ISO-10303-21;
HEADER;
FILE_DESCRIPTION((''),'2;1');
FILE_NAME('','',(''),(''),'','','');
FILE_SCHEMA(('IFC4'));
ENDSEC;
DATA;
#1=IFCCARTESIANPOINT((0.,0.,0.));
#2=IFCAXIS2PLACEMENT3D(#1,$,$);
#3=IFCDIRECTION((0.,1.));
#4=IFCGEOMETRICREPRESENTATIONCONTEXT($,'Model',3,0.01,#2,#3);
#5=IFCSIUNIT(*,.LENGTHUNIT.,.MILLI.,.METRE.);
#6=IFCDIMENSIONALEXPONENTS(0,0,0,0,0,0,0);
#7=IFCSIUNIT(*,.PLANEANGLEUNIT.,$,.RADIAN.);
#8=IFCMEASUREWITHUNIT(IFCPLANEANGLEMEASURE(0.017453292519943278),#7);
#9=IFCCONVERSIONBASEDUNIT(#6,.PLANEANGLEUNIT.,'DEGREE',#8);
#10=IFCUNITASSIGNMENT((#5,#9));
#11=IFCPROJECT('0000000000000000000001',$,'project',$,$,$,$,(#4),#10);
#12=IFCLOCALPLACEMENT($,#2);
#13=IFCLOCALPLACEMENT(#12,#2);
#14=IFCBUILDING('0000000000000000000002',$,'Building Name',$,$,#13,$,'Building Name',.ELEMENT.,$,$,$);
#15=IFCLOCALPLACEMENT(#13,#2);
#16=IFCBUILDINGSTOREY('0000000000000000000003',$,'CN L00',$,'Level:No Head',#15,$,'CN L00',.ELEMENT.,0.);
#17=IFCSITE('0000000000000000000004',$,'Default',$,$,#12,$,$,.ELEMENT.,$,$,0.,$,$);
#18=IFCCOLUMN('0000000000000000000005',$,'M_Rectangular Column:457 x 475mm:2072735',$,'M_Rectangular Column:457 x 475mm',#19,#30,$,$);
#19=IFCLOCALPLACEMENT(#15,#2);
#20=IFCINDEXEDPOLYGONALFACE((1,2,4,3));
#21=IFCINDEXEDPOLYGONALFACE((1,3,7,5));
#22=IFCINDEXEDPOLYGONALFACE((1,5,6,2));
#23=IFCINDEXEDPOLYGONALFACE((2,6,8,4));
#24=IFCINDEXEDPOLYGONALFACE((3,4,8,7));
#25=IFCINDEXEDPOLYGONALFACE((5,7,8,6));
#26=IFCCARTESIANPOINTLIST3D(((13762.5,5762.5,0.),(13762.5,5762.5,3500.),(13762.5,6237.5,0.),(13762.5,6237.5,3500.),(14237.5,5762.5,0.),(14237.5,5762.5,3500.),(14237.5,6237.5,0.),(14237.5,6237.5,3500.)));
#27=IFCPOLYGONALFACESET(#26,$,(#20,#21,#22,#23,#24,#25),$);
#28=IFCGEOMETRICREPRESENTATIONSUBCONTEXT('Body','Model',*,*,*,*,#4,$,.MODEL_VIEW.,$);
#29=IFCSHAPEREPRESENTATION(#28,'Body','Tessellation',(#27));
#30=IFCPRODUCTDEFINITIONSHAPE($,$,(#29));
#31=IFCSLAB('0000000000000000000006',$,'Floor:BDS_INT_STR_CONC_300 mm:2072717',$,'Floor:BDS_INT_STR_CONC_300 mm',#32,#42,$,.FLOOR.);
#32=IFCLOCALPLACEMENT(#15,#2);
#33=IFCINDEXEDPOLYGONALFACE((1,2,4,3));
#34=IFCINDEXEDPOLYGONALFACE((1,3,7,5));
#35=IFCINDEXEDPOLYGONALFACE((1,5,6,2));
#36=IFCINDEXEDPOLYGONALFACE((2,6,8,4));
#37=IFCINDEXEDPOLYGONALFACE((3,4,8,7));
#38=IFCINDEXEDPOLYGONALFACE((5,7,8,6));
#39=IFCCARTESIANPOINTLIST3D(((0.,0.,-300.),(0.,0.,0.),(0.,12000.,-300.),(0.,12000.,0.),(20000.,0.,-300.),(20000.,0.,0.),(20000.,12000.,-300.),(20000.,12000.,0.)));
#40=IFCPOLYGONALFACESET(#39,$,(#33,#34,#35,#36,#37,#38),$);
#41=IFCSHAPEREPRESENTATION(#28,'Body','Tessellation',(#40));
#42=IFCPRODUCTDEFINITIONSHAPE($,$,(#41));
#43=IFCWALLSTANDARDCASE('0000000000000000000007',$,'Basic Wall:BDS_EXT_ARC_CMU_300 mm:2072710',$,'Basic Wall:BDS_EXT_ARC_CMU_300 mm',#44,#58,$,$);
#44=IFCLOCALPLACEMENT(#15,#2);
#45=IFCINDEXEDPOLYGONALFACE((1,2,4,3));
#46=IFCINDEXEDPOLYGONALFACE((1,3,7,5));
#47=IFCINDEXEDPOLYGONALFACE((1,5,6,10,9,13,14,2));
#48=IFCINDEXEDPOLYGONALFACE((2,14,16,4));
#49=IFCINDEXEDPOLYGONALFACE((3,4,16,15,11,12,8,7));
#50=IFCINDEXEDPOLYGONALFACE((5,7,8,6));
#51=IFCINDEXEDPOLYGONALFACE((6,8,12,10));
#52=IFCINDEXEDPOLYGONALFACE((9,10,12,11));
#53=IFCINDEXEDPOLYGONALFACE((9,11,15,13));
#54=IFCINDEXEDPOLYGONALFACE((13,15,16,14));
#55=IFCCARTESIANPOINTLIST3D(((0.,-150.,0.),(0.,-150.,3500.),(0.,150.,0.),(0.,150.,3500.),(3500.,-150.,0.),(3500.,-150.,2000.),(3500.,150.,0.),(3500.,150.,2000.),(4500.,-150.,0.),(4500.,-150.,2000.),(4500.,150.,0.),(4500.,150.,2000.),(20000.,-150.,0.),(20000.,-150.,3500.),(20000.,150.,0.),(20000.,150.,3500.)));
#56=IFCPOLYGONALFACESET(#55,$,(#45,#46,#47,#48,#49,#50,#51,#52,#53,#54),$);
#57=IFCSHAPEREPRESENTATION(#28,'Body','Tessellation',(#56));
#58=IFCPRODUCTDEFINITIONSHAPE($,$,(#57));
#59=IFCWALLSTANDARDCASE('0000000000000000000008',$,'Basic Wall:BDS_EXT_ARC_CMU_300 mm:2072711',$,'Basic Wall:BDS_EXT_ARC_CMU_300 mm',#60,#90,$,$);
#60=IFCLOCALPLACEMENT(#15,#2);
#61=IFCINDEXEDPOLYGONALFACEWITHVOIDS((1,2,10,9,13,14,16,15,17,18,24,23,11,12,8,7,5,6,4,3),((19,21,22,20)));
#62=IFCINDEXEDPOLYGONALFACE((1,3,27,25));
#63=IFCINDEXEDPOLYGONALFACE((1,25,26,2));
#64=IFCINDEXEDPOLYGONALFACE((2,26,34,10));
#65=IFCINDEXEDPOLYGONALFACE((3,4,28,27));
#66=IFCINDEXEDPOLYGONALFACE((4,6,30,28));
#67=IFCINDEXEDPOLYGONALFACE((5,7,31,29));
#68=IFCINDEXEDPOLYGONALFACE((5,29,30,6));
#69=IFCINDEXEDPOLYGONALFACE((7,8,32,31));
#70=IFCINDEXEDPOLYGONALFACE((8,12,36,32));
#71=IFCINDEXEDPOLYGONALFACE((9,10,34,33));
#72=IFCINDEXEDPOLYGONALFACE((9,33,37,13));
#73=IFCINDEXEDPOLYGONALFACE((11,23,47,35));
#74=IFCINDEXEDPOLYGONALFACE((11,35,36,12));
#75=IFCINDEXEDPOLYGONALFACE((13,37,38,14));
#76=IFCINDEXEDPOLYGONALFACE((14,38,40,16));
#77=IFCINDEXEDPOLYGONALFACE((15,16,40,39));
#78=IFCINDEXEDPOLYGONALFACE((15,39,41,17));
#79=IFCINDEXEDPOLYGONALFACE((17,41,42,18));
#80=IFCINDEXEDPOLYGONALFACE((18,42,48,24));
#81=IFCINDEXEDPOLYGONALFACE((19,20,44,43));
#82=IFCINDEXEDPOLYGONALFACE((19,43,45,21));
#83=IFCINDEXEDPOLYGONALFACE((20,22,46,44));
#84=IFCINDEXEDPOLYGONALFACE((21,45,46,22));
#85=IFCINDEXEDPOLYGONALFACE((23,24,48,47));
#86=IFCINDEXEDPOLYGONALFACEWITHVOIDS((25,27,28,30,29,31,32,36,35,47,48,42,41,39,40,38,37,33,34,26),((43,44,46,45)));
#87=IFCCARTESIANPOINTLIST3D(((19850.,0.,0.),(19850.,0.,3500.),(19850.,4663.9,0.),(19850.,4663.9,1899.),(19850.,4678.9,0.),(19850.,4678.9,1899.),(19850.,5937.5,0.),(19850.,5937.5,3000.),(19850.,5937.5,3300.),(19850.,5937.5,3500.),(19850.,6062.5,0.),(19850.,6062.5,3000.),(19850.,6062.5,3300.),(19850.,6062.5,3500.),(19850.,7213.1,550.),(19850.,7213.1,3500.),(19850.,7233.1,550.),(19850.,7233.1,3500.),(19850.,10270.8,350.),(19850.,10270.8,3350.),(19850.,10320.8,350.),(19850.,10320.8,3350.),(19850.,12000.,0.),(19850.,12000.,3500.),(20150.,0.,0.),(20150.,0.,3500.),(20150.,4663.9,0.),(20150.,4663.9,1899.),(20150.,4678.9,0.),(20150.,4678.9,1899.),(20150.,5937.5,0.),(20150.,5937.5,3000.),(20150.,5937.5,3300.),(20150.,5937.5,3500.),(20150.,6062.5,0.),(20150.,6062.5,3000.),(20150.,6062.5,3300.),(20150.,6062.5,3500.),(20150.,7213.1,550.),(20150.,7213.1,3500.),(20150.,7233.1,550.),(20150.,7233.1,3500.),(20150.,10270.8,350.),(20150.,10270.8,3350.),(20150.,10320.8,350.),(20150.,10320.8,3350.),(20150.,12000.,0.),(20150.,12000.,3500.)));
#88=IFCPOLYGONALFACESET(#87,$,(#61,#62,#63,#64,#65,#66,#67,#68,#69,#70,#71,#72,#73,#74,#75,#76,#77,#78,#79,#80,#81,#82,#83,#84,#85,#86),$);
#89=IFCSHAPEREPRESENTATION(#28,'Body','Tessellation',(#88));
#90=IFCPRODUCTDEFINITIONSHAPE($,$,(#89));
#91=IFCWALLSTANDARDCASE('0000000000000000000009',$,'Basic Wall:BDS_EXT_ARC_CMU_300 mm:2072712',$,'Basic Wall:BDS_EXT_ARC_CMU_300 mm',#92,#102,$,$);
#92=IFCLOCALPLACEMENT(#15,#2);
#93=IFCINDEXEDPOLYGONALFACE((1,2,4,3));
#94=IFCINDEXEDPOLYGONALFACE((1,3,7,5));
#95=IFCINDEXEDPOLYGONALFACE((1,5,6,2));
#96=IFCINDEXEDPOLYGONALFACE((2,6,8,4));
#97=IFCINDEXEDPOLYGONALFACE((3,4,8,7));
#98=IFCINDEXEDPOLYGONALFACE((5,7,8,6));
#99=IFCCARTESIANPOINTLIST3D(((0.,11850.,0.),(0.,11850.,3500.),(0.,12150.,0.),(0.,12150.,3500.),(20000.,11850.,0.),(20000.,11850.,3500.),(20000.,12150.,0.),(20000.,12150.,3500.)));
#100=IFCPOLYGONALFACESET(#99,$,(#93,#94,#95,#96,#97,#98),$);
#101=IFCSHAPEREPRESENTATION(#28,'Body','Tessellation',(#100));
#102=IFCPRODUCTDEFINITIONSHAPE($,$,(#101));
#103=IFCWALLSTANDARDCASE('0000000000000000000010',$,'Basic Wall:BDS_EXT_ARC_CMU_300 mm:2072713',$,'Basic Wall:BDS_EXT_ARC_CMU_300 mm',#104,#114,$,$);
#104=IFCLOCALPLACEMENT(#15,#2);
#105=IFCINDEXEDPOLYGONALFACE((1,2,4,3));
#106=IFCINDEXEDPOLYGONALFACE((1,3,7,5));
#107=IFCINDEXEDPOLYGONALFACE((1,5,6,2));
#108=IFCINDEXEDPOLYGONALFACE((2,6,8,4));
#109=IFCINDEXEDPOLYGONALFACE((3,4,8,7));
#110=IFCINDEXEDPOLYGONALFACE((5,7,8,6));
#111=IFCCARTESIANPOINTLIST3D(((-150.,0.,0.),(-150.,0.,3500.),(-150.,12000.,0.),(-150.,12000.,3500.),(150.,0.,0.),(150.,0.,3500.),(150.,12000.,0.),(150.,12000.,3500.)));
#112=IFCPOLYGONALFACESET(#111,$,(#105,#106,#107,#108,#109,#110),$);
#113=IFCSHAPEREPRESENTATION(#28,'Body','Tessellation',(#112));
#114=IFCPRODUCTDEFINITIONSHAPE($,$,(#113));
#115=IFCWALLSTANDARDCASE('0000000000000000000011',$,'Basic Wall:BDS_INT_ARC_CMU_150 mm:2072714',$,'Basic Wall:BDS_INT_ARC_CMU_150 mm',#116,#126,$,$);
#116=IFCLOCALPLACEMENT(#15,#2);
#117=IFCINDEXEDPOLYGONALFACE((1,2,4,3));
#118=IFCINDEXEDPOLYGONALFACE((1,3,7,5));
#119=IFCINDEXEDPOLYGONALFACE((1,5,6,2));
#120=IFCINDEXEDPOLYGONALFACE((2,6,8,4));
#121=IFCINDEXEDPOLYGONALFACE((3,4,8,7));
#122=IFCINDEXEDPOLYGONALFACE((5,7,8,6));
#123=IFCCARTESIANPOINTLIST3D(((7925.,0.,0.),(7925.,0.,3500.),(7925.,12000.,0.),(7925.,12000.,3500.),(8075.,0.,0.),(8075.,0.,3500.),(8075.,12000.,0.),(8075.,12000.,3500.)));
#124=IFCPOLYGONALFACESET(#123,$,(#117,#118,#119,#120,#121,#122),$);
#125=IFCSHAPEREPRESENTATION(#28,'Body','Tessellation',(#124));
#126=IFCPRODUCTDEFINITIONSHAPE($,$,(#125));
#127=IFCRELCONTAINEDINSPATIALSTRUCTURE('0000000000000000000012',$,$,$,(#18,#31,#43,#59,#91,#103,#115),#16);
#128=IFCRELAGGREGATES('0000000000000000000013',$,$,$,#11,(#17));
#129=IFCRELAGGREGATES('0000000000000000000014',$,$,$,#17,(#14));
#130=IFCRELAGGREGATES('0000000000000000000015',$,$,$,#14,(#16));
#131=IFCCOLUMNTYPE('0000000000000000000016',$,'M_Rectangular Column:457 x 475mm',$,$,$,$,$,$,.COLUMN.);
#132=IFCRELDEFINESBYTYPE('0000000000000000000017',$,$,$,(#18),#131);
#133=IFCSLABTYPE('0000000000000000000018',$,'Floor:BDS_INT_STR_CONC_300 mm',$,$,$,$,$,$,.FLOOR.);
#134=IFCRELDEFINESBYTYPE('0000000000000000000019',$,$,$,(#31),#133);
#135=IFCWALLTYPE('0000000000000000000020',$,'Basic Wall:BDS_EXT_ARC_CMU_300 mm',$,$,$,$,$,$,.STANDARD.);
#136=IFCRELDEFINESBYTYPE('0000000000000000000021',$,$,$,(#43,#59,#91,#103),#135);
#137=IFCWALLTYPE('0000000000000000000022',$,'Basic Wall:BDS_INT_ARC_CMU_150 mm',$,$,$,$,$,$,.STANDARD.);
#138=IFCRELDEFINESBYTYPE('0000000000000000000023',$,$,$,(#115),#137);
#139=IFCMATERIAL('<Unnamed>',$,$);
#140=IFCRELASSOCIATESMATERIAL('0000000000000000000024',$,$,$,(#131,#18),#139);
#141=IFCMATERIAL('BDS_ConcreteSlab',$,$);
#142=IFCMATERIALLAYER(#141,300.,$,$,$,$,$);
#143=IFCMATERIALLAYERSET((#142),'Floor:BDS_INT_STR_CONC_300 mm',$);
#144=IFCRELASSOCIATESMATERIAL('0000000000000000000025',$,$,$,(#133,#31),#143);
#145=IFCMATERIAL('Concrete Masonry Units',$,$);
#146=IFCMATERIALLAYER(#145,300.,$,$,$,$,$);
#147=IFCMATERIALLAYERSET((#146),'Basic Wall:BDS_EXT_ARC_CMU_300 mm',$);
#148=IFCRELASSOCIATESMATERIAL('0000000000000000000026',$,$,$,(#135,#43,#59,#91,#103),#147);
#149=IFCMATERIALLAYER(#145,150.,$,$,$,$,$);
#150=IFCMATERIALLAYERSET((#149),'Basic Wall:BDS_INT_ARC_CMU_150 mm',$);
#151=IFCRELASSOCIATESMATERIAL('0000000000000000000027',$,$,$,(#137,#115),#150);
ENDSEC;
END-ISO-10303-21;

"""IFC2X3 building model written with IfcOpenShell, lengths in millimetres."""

from ifc_helpers import new_model, entity, si_unit, converted_unit, direction, frame, frame_2d, origin, origin_2d_with_axis, place, context, subcontext, project, spatial, polyline, rectangle, extrude, clip, bounded_halfspace, source, transform, mapped, material, layer, layer_set, layer_usage, type_object, type_shapes, element, save


model = new_model("IFC2X3")

# Units and contexts
model_context = context("Model", 3, precision=0.01, world=origin(), true_north=direction((0.0, 1.0)))
body_context = subcontext(model_context, "Body", "Model", "MODEL_VIEW")
ifc_project = project(units=[si_unit("LENGTHUNIT", "METRE", prefix="MILLI"), converted_unit("PLANEANGLEUNIT", "DEGREE", entity("IfcPlaneAngleMeasure", 0.017453292519943278), si_unit("PLANEANGLEUNIT", "RADIAN"), dimensions=[0, 0, 0, 0, 0, 0, 0])], contexts=[model_context])

# Site, building, storey
site_placement = place(None, origin())
site = spatial("IfcSite", under=ifc_project, at=site_placement, Name="Default", CompositionType="ELEMENT", RefElevation=0.0)
building_placement = place(site_placement, origin())
building = spatial("IfcBuilding", under=site, at=building_placement, Name="Building Name", LongName="Building Name", CompositionType="ELEMENT")
storey_placement = place(building_placement, origin())
storey = spatial("IfcBuildingStorey", under=building, at=storey_placement, Name="CN L00", ObjectType="Level:No Head", LongName="CN L00", CompositionType="ELEMENT", Elevation=0.0)

# Column
ifc_material_1 = material(Name="<Unnamed>")
column_type = type_object("IfcColumnType", Name="M_Rectangular Column:457 x 475mm", PredefinedType="COLUMN", material=ifc_material_1)
shared_shape = source(origin(), body_context, "Body", "SweptSolid", [
    extrude(rectangle(XDim=475.0, YDim=475.0, at=origin_2d_with_axis()), frame((0.0, 0.0, 0.0), z_axis=(0.0, 0.0, 1.0), x_axis=(-1.0, 0.0, 0.0)), (0.0, 0.0, 1.0), 3500.0),
])
type_shapes(column_type, [shared_shape])
column_placement = place(storey_placement, frame((14000.0, 6000.0, 0.0)))
element("IfcColumn", 1, at=column_placement, inside=storey, type_object=column_type, material=ifc_material_1, Name="M_Rectangular Column:457 x 475mm:2072735", ObjectType="M_Rectangular Column:457 x 475mm", context=body_context, shape_type="MappedRepresentation", body=[
    mapped(shared_shape, transform((0.0, 0.0, 0.0), scale=1.0)),
])

# Slab
ifc_material_2 = material(Name="BDS_ConcreteSlab")
ifc_layer_1 = layer(ifc_material_2, 300.0)
ifc_layer_set_1 = layer_set([ifc_layer_1], Name="Floor:BDS_INT_STR_CONC_300 mm")
ifc_layer_usage_1 = layer_usage(ifc_layer_set_1, "AXIS3", "POSITIVE", 0.0)
slab_type = type_object("IfcSlabType", Name="Floor:BDS_INT_STR_CONC_300 mm", PredefinedType="FLOOR", material=ifc_layer_set_1)
slab_placement = place(storey_placement, origin())
element("IfcSlab", 2, at=slab_placement, inside=storey, type_object=slab_type, material=ifc_layer_usage_1, Name="Floor:BDS_INT_STR_CONC_300 mm:2072717", ObjectType="Floor:BDS_INT_STR_CONC_300 mm", PredefinedType="FLOOR", context=body_context, shape_type="SweptSolid", body=[
    extrude(rectangle(XDim=12000.0, YDim=20000.0, at=origin_2d_with_axis()), frame((10000.0, 6000.0, 0.0), z_axis=(0.0, 0.0, -1.0), x_axis=(0.0, 1.0, 0.0)), (0.0, 0.0, 1.0), 300.0),
])

# Walls, openings
ifc_material_3 = material(Name="Concrete Masonry Units")
ifc_layer_2 = layer(ifc_material_3, 300.0)
ifc_layer_set_2 = layer_set([ifc_layer_2], Name="Basic Wall:BDS_EXT_ARC_CMU_300 mm")
ifc_layer_usage_2 = layer_usage(ifc_layer_set_2, "AXIS2", "NEGATIVE", 150.0)
wall_type_1 = type_object("IfcWallType", Name="Basic Wall:BDS_EXT_ARC_CMU_300 mm", PredefinedType="STANDARD", material=ifc_layer_set_2)
wall_1_placement = place(storey_placement, origin())
wall_1 = element("IfcWallStandardCase", 3, at=wall_1_placement, inside=storey, type_object=wall_type_1, material=ifc_layer_usage_2, Name="Basic Wall:BDS_EXT_ARC_CMU_300 mm:2072710", ObjectType="Basic Wall:BDS_EXT_ARC_CMU_300 mm", context=body_context, shape_type="SweptSolid", body=[
    extrude(rectangle(XDim=20000.0, YDim=300.0, at=frame_2d((10000.0, 0.0), x_axis=(1.0, 0.0))), origin(), (0.0, 0.0, 1.0), 3500.0),
])
opening_1_placement = place(wall_1_placement, frame((3500.0, -150.0, 0.0)))
element("IfcOpeningElement", 4, at=opening_1_placement, cuts=wall_1, ObjectType="Opening", context=body_context, shape_type="SweptSolid", body=[
    extrude(rectangle(XDim=1000.0, YDim=2000.0, at=frame_2d((1000.0, 500.0), x_axis=(0.0, 1.0))), frame((0.0, 0.0, 0.0), z_axis=(0.0, 1.0, 0.0), x_axis=(0.0, 0.0, 1.0)), (0.0, 0.0, 1.0), 300.0),
])
ifc_layer_usage_3 = layer_usage(ifc_layer_set_2, "AXIS2", "NEGATIVE", 150.0)
wall_2_placement = place(storey_placement, frame((20000.0, 0.0, 0.0), z_axis=(0.0, 0.0, 1.0), x_axis=(0.0, 1.0, 0.0)))
wall_2 = element("IfcWallStandardCase", 5, at=wall_2_placement, inside=storey, type_object=wall_type_1, material=ifc_layer_usage_3, Name="Basic Wall:BDS_EXT_ARC_CMU_300 mm:2072711", ObjectType="Basic Wall:BDS_EXT_ARC_CMU_300 mm", context=body_context, shape_type="Clipping", body=[
    clip(clip(clip(clip(extrude(rectangle(XDim=12000.0, YDim=300.0, at=frame_2d((6000.0, 0.0), x_axis=(-1.0, 0.0))), origin(), (0.0, 0.0, 1.0), 3500.0), bounded_halfspace(frame((7213.1, 150.0, 550.0), z_axis=(0.0, 0.0, -1.0), x_axis=(1.0, 0.0, 0.0)), True, frame((7213.1, 150.0, 550.0), z_axis=(0.0, 0.0, -1.0), x_axis=(1.0, 0.0, 0.0)), polyline([(0.0, 0.0), (20.0, 0.0), (20.0, 300.0), (0.0, 300.0), (0.0, 0.0)]))), bounded_halfspace(frame((4663.9, -150.0, 1899.0)), True, frame((4663.9, -150.0, 1899.0)), polyline([(0.0, 0.0), (15.0, 0.0), (15.0, 300.0), (0.0, 300.0), (0.0, 0.0)]))), bounded_halfspace(frame((5937.5, -150.0, 3000.0)), True, frame((5937.5, -150.0, 3000.0)), polyline([(0.0, 0.0), (125.0, 0.0), (125.0, 300.0), (0.0, 300.0), (0.0, 0.0)]))), bounded_halfspace(frame((5937.5, 150.0, 3300.0), z_axis=(0.0, 0.0, -1.0), x_axis=(1.0, 0.0, 0.0)), True, frame((5937.5, 150.0, 3300.0), z_axis=(0.0, 0.0, -1.0), x_axis=(1.0, 0.0, 0.0)), polyline([(0.0, 0.0), (125.0, 0.0), (125.0, 300.0), (0.0, 300.0), (0.0, 0.0)]))),
])
opening_2_placement = place(storey_placement, frame((20000.0, 0.0, 0.0), z_axis=(0.0, 0.0, 1.0), x_axis=(0.0, 1.0, 0.0)))
element("IfcOpeningElement", 6, at=opening_2_placement, cuts=wall_2, ObjectType="Opening", context=body_context, shape_type="SweptSolid", body=[
    extrude(rectangle(XDim=300.0, YDim=50.0, at=origin_2d_with_axis()), frame((10295.8, 0.0, 350.0), z_axis=(0.0, 0.0, 1.0), x_axis=(0.0, 1.0, 0.0)), (0.0, 0.0, 1.0), 3000.0),
])

# Walls
ifc_layer_usage_4 = layer_usage(ifc_layer_set_2, "AXIS2", "NEGATIVE", 150.0)
wall_3_placement = place(storey_placement, frame((20000.0, 12000.0, 0.0), z_axis=(0.0, 0.0, 1.0), x_axis=(-1.0, 0.0, 0.0)))
element("IfcWallStandardCase", 7, at=wall_3_placement, inside=storey, type_object=wall_type_1, material=ifc_layer_usage_4, Name="Basic Wall:BDS_EXT_ARC_CMU_300 mm:2072712", ObjectType="Basic Wall:BDS_EXT_ARC_CMU_300 mm", context=body_context, shape_type="SweptSolid", body=[
    extrude(rectangle(XDim=20000.0, YDim=300.0, at=frame_2d((10000.0, 0.0), x_axis=(-1.0, 0.0))), origin(), (0.0, 0.0, 1.0), 3500.0),
])
ifc_layer_usage_5 = layer_usage(ifc_layer_set_2, "AXIS2", "NEGATIVE", 150.0)
wall_4_placement = place(storey_placement, frame((0.0, 12000.0, 0.0), z_axis=(0.0, 0.0, 1.0), x_axis=(0.0, -1.0, 0.0)))
element("IfcWallStandardCase", 8, at=wall_4_placement, inside=storey, type_object=wall_type_1, material=ifc_layer_usage_5, Name="Basic Wall:BDS_EXT_ARC_CMU_300 mm:2072713", ObjectType="Basic Wall:BDS_EXT_ARC_CMU_300 mm", context=body_context, shape_type="SweptSolid", body=[
    extrude(rectangle(XDim=12000.0, YDim=300.0, at=frame_2d((6000.0, 0.0), x_axis=(-1.0, 0.0))), origin(), (0.0, 0.0, 1.0), 3500.0),
])
ifc_layer_3 = layer(ifc_material_3, 150.0)
ifc_layer_set_3 = layer_set([ifc_layer_3], Name="Basic Wall:BDS_INT_ARC_CMU_150 mm")
ifc_layer_usage_6 = layer_usage(ifc_layer_set_3, "AXIS2", "NEGATIVE", 75.0)
wall_type_2 = type_object("IfcWallType", Name="Basic Wall:BDS_INT_ARC_CMU_150 mm", PredefinedType="STANDARD", material=ifc_layer_set_3)
wall_5_placement = place(storey_placement, frame((8000.0, 0.0, 0.0), z_axis=(0.0, 0.0, 1.0), x_axis=(0.0, 1.0, 0.0)))
element("IfcWallStandardCase", 9, at=wall_5_placement, inside=storey, type_object=wall_type_2, material=ifc_layer_usage_6, Name="Basic Wall:BDS_INT_ARC_CMU_150 mm:2072714", ObjectType="Basic Wall:BDS_INT_ARC_CMU_150 mm", context=body_context, shape_type="SweptSolid", body=[
    extrude(rectangle(XDim=12000.0, YDim=150.0, at=frame_2d((6000.0, 0.0), x_axis=(-1.0, 0.0))), origin(), (0.0, 0.0, 1.0), 3500.0),
])

save(model, "model.ifc")
